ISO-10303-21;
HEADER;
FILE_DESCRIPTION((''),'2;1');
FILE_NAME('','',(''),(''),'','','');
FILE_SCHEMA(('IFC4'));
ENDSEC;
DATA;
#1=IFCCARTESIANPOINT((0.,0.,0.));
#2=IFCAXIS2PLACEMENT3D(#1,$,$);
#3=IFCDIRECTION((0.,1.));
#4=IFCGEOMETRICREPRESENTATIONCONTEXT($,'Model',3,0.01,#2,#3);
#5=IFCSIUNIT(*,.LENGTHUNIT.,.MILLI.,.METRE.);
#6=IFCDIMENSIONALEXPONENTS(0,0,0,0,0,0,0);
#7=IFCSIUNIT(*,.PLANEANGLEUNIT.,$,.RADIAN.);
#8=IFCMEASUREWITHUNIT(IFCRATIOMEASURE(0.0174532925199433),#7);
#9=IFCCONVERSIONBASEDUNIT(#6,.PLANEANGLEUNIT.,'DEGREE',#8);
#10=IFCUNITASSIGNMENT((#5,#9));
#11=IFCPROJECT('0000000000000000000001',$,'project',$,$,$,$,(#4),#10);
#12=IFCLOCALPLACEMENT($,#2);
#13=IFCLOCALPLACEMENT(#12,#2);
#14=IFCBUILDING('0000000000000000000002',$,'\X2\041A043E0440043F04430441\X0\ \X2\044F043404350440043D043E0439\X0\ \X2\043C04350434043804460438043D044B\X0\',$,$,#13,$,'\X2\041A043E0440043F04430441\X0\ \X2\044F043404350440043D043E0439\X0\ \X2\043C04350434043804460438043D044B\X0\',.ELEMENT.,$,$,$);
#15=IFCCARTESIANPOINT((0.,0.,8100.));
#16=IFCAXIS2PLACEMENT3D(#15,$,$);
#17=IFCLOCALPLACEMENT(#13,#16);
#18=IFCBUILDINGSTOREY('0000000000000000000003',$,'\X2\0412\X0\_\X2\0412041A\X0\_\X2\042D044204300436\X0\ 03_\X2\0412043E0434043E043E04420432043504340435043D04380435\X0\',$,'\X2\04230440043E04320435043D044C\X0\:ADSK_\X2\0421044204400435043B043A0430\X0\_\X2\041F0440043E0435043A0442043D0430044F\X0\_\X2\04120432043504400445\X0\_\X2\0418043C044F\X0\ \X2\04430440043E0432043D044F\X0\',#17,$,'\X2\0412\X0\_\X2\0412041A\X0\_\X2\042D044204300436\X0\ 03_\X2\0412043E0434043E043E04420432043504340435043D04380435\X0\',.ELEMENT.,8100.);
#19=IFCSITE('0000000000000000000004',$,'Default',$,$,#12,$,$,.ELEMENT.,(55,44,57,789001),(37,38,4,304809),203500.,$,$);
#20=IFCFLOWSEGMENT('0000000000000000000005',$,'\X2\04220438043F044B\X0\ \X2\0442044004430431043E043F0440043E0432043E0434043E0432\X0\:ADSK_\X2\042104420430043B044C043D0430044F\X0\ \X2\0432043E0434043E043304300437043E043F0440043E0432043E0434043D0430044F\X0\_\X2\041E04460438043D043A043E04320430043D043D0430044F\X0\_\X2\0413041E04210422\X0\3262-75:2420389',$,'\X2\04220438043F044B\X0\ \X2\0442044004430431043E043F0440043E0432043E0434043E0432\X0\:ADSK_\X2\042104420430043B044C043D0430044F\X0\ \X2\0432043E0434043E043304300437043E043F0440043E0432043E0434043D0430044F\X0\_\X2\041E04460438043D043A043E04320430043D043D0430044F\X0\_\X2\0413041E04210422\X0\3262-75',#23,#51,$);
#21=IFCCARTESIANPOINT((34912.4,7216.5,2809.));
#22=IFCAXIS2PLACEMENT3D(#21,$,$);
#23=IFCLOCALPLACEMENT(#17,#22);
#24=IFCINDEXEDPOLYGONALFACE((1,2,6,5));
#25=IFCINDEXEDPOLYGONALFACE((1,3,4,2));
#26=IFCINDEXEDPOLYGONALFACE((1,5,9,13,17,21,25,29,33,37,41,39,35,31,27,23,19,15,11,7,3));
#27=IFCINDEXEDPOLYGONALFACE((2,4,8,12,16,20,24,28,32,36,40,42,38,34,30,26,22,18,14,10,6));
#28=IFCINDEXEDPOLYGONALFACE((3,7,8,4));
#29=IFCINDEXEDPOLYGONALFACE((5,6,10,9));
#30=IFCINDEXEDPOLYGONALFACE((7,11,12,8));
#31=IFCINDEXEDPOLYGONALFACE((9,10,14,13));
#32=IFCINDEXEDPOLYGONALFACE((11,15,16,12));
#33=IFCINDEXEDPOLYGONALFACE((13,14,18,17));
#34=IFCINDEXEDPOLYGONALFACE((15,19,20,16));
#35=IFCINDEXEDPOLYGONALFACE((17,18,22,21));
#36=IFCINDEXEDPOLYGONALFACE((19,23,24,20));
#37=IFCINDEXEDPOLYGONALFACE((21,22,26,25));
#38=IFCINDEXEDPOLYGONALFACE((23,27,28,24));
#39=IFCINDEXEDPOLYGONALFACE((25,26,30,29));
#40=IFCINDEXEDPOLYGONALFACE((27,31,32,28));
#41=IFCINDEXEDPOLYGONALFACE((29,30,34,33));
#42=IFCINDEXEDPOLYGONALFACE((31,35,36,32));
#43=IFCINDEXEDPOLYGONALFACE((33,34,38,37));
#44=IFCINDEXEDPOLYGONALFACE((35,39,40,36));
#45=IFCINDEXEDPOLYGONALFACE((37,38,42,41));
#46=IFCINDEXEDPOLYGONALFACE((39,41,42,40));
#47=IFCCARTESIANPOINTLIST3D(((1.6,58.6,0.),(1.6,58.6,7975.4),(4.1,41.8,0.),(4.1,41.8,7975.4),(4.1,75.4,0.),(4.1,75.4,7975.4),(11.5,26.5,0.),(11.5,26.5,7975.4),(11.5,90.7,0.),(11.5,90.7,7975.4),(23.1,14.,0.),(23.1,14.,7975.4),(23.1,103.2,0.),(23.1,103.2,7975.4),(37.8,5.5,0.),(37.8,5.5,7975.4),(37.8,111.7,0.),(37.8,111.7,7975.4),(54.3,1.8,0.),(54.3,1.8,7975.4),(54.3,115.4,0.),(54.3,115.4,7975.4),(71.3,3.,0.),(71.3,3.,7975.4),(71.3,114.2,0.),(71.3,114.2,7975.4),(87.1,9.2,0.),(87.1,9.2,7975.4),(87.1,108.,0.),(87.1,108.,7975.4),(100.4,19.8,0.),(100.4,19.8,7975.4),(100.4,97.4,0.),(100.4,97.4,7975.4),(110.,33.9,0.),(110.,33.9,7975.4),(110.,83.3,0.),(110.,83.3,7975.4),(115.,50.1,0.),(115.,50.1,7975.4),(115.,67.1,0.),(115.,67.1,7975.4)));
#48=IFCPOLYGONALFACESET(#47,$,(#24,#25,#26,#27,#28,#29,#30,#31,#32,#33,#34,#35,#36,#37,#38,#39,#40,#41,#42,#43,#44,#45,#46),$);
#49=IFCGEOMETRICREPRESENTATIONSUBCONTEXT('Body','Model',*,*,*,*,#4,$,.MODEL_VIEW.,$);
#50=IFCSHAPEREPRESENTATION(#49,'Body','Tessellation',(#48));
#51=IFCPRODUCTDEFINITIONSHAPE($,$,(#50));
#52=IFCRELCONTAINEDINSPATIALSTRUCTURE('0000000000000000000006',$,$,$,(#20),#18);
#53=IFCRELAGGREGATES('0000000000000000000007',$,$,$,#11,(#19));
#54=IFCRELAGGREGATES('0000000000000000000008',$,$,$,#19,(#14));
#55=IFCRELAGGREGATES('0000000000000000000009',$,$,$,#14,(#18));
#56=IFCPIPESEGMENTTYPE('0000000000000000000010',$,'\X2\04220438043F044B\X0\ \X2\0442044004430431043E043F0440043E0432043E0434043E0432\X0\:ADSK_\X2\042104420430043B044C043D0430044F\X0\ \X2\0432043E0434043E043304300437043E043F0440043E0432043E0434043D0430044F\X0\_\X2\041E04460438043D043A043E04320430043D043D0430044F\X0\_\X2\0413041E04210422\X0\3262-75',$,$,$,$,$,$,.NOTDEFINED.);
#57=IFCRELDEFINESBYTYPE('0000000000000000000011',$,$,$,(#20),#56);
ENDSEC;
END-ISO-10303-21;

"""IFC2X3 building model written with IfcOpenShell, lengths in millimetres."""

from ifc_helpers import new_model, entity, si_unit, converted_unit, direction, frame, origin, origin_2d_with_axis, place, context, subcontext, project, spatial, circle, extrude, type_object, element, save


model = new_model("IFC2X3")

# Units and contexts
model_context = context("Model", 3, precision=0.01, world=origin(), true_north=direction((0.0, 1.0)))
body_context = subcontext(model_context, "Body", "Model", "MODEL_VIEW")
ifc_project = project(units=[si_unit("LENGTHUNIT", "METRE", prefix="MILLI"), converted_unit("PLANEANGLEUNIT", "DEGREE", entity("IfcRatioMeasure", 0.0174532925199433), si_unit("PLANEANGLEUNIT", "RADIAN"), dimensions=[0, 0, 0, 0, 0, 0, 0])], contexts=[model_context])

# Site, building, storey
site_placement = place(None, origin())
site = spatial("IfcSite", under=ifc_project, at=site_placement, Name="Default", CompositionType="ELEMENT", RefLatitude=(55, 44, 57, 789001), RefLongitude=(37, 38, 4, 304809), RefElevation=203500.0)
building_placement = place(site_placement, origin())
building = spatial("IfcBuilding", under=site, at=building_placement, Name="Корпус ядерной медицины", LongName="Корпус ядерной медицины", CompositionType="ELEMENT")
storey_placement = place(building_placement, frame((0.0, 0.0, 8100.0)))
storey = spatial("IfcBuildingStorey", under=building, at=storey_placement, Name="В_ВК_Этаж 03_Водоотведение", ObjectType="Уровень:ADSK_Стрелка_Проектная_Вверх_Имя уровня", LongName="В_ВК_Этаж 03_Водоотведение", CompositionType="ELEMENT", Elevation=8100.0)

# Flow segment
pipe_segment_type_1 = type_object("IfcPipeSegmentType", Name="Типы трубопроводов:ADSK_Стальная водогазопроводная_Оцинкованная_ГОСТ3262-75", PredefinedType="NOTDEFINED")
flow_segment_1_placement = place(storey_placement, frame((34912.4, 7216.5, 2809.0)))
element("IfcFlowSegment", 1, at=flow_segment_1_placement, inside=storey, type_object=pipe_segment_type_1, Name="Типы трубопроводов:ADSK_Стальная водогазопроводная_Оцинкованная_ГОСТ3262-75:2420389", ObjectType="Типы трубопроводов:ADSK_Стальная водогазопроводная_Оцинкованная_ГОСТ3262-75", context=body_context, shape_type="SweptSolid", body=[
    extrude(circle(Radius=57.0, at=origin_2d_with_axis()), frame((58.6, 58.6, 0.0), z_axis=(0.0, 0.000001, 1.0), x_axis=(-1.0, 0.0, 0.0)), (0.0, 0.0, 1.0), 7975.4),
])

save(model, "model.ifc")
